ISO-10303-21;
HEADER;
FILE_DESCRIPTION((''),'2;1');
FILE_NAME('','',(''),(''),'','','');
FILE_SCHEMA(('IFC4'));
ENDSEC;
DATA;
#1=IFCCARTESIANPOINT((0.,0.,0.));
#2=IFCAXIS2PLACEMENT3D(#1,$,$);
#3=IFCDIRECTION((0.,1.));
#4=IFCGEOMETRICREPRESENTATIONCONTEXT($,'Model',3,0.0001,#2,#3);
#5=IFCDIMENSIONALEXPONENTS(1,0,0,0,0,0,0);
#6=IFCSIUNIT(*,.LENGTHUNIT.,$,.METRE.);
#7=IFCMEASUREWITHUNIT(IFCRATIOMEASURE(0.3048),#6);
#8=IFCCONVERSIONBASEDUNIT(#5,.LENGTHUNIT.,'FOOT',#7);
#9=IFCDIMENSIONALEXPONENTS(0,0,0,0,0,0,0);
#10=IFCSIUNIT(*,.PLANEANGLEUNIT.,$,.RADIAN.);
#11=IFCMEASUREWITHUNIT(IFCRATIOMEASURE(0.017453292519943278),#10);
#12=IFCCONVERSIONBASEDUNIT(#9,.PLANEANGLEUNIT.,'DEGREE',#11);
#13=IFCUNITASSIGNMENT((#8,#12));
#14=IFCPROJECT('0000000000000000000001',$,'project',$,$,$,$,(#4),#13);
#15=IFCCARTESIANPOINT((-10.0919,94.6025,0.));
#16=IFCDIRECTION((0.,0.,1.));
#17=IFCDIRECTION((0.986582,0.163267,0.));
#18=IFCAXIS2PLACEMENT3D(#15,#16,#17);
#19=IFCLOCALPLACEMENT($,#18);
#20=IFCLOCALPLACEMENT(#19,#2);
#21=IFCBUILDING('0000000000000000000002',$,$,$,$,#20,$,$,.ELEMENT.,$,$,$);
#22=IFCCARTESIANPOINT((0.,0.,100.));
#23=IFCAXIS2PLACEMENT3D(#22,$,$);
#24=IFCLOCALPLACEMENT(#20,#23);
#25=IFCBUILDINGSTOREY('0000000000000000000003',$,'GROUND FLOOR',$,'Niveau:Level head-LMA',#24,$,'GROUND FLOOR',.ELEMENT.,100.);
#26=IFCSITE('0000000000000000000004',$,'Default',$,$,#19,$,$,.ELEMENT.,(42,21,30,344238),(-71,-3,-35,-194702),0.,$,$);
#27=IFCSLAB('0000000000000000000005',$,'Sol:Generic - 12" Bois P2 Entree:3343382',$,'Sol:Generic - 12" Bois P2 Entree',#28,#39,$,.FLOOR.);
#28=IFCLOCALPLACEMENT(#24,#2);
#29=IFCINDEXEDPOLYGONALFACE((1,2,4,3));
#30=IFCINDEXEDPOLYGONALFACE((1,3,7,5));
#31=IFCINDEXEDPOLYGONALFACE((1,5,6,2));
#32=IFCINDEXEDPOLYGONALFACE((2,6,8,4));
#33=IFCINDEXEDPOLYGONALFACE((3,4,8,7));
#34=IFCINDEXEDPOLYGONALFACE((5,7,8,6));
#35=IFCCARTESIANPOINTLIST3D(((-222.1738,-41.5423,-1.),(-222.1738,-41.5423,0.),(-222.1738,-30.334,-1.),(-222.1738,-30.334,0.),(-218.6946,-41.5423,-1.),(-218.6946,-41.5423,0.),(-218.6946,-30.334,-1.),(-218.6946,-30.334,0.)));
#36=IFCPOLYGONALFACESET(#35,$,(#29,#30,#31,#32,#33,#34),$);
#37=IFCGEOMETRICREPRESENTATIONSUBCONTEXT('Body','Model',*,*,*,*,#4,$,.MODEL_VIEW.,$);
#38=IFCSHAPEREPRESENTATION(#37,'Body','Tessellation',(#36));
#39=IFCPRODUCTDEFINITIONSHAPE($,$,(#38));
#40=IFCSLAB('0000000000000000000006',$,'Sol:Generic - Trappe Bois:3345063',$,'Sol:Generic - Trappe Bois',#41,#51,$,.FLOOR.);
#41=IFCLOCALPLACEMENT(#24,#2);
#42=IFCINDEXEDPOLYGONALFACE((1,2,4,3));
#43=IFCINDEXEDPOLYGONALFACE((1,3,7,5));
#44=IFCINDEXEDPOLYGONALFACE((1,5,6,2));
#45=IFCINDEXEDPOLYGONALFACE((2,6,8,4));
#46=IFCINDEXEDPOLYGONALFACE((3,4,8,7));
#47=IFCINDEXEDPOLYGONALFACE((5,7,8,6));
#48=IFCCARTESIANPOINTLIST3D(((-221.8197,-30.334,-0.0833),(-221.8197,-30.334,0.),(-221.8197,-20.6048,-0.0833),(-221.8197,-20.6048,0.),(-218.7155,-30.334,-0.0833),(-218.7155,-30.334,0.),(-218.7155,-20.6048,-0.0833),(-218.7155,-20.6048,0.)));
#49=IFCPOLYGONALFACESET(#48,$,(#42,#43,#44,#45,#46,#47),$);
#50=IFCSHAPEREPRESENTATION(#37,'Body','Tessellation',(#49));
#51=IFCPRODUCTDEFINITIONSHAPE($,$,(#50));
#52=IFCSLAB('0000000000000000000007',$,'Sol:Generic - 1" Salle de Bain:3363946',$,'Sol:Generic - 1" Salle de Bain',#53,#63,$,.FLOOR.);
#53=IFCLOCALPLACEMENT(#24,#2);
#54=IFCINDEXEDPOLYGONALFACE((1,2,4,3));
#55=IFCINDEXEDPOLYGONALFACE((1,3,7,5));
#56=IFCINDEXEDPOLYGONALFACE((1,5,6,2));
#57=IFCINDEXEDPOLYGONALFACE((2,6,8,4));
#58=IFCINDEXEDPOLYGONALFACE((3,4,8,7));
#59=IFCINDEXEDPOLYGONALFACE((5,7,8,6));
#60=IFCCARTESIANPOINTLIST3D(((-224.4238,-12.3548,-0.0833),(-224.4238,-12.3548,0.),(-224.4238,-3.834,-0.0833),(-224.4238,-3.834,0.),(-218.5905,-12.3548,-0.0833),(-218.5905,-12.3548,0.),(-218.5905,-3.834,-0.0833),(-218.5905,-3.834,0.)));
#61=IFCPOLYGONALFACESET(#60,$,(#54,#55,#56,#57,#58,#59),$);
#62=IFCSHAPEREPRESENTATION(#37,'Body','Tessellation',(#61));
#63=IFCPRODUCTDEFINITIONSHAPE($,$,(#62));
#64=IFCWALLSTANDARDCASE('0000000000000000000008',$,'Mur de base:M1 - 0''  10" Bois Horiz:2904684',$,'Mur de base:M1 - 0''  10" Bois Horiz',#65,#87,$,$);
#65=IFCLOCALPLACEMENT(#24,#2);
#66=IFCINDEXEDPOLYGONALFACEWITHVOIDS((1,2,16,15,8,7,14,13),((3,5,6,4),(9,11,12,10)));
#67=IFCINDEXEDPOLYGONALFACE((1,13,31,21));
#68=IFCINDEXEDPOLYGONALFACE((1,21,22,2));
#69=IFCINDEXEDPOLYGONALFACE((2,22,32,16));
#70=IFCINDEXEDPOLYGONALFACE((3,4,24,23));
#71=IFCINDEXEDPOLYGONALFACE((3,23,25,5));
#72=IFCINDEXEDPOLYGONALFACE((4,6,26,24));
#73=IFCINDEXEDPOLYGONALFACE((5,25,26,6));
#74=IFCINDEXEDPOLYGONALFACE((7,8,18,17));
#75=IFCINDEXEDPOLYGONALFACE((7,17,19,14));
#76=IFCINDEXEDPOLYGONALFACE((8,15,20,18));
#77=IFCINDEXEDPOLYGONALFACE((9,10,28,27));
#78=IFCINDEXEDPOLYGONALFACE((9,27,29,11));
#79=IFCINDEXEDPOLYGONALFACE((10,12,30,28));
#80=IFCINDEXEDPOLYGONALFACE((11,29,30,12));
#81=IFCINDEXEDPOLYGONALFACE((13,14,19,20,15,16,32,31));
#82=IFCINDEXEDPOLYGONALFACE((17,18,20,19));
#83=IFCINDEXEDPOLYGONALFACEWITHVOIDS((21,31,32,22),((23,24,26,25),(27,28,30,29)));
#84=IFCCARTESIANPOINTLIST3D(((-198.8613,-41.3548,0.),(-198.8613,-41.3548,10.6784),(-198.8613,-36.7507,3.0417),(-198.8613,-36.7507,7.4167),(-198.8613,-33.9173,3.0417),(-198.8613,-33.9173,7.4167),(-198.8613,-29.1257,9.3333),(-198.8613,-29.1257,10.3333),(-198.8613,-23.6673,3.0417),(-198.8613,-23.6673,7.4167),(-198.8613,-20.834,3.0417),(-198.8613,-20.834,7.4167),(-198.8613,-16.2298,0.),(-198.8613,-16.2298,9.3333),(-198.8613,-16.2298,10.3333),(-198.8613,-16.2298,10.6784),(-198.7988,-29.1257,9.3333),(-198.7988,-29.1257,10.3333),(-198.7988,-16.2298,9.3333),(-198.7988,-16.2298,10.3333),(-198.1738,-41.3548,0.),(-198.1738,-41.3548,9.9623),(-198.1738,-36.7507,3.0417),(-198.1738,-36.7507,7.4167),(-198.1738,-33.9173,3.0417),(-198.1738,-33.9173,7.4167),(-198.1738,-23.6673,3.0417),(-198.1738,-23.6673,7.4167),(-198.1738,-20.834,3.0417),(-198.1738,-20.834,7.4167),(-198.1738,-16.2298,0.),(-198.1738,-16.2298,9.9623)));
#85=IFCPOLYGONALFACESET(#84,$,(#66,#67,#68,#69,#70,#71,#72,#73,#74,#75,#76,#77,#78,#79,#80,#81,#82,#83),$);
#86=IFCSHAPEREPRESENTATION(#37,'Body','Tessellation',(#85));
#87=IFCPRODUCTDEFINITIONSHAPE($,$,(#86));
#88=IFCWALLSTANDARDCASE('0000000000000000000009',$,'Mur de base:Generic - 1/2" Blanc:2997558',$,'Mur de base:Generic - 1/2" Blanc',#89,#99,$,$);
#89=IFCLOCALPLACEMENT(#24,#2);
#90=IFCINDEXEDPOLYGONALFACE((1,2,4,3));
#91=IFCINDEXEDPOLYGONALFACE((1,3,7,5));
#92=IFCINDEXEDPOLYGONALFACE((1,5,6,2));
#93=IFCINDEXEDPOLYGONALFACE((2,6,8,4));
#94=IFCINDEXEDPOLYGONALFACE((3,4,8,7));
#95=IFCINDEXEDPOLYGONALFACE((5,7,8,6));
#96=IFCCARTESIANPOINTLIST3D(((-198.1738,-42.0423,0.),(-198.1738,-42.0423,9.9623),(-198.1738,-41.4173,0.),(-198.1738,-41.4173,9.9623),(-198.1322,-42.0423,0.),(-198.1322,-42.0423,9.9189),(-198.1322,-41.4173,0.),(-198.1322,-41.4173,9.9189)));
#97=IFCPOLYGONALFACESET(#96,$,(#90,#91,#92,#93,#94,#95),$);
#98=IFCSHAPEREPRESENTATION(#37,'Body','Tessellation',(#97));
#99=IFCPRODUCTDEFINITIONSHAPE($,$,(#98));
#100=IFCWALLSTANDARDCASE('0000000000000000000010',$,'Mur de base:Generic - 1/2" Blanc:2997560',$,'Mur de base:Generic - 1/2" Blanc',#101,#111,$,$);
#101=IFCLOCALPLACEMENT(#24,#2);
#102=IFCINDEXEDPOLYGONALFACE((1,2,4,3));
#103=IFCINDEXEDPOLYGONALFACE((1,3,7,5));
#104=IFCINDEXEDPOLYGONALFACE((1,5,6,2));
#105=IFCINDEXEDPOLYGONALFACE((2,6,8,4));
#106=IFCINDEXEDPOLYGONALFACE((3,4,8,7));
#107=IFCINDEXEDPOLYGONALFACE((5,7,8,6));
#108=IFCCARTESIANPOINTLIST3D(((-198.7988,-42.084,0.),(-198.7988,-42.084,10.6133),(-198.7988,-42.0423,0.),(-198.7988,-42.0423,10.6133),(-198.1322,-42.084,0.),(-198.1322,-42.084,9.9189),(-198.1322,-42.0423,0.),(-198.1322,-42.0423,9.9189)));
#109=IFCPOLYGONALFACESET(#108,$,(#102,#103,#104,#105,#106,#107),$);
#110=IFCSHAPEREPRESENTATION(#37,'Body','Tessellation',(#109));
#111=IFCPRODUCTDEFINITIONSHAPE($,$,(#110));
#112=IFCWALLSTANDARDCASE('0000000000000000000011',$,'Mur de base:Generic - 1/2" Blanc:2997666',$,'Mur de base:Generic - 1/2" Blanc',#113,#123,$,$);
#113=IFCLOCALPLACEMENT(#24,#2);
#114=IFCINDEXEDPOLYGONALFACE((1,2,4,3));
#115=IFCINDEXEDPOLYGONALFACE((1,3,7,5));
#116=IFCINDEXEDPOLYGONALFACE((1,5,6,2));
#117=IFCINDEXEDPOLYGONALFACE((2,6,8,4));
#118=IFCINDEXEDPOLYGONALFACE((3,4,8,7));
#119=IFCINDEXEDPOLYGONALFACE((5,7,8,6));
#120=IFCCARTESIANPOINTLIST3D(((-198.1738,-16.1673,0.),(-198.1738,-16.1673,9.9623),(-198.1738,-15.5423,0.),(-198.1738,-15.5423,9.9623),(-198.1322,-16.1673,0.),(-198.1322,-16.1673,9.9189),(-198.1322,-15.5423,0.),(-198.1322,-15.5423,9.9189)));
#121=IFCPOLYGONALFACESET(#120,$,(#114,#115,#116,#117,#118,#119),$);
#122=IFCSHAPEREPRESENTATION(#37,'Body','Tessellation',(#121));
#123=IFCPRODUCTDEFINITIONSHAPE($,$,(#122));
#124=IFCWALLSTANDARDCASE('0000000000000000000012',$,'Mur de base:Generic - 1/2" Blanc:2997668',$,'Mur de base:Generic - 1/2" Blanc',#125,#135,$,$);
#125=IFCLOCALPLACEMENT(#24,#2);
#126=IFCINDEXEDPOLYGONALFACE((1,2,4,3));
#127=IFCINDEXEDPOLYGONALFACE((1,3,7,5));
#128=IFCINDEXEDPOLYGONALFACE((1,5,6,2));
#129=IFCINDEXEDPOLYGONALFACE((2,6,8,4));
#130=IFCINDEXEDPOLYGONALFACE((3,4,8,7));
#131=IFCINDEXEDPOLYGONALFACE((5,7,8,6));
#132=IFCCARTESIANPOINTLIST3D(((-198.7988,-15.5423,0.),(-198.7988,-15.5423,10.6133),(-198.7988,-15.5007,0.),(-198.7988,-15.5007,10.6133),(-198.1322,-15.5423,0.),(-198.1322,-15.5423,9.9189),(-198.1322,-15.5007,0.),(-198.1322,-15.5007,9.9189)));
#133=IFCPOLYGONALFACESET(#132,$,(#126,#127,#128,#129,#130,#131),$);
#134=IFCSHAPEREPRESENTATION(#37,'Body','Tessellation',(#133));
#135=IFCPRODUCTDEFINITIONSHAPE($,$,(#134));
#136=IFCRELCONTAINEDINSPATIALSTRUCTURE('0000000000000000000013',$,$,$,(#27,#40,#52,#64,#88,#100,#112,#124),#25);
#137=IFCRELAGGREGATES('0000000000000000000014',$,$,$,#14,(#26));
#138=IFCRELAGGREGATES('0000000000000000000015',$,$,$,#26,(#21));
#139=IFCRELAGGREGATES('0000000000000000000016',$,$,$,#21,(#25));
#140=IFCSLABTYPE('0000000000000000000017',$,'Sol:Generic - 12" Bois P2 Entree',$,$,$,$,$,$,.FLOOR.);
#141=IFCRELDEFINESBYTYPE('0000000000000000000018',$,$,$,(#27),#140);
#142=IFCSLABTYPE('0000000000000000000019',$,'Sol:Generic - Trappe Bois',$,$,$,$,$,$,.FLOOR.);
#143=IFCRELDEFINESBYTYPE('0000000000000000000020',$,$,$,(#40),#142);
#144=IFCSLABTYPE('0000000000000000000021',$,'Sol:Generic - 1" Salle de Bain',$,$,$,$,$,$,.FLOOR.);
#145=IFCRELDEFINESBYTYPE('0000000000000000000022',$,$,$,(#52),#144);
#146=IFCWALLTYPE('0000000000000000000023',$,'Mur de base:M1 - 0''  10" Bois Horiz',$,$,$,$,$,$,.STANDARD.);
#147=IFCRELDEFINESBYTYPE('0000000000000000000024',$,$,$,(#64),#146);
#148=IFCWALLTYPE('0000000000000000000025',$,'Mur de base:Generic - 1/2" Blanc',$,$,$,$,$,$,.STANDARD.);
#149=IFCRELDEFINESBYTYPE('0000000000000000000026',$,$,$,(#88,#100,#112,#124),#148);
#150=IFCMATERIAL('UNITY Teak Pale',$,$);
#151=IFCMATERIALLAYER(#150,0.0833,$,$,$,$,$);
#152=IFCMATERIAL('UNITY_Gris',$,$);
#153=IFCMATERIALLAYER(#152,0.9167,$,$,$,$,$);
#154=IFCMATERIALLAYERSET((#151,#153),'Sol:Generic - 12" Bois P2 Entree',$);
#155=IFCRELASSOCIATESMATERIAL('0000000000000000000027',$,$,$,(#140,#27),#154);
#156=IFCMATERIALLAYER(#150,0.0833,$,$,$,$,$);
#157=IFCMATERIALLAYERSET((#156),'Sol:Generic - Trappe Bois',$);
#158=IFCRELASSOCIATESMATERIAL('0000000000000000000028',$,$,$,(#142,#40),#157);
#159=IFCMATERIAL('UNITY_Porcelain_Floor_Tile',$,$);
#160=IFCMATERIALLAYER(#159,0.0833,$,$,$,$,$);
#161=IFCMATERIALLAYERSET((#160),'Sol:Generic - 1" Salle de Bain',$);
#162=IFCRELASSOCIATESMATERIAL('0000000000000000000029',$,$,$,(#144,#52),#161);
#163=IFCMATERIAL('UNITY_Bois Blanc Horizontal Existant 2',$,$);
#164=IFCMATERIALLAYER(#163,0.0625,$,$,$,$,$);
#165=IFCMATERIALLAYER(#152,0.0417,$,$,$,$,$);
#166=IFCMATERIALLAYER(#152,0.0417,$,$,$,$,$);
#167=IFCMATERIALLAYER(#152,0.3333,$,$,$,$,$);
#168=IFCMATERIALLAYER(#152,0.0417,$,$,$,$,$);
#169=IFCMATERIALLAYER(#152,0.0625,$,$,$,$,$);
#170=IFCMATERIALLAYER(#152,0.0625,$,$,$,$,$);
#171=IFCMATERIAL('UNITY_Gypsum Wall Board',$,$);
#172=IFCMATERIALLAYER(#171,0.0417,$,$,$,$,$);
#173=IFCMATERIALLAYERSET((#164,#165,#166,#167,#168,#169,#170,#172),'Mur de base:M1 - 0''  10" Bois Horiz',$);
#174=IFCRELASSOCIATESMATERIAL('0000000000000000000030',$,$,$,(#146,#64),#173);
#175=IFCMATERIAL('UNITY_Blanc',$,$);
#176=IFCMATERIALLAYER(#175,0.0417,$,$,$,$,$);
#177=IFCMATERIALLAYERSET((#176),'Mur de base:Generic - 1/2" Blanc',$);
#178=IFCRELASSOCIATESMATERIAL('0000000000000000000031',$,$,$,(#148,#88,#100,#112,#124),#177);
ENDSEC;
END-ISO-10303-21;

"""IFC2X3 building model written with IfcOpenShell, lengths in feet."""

from ifc_helpers import new_model, entity, si_unit, converted_unit, direction, frame, frame_2d, origin, place, context, subcontext, project, spatial, polyline, rectangle, extrude, clip, bounded_halfspace, material, layer, layer_set, layer_usage, type_object, element, save


model = new_model("IFC2X3")

# Units and contexts
model_context = context("Model", 3, precision=0.0001, world=origin(), true_north=direction((0.0, 1.0)))
body_context = subcontext(model_context, "Body", "Model", "MODEL_VIEW")
ifc_project = project(units=[converted_unit("LENGTHUNIT", "FOOT", entity("IfcRatioMeasure", 0.3048), si_unit("LENGTHUNIT", "METRE"), dimensions=[1, 0, 0, 0, 0, 0, 0]), converted_unit("PLANEANGLEUNIT", "DEGREE", entity("IfcRatioMeasure", 0.017453292519943278), si_unit("PLANEANGLEUNIT", "RADIAN"), dimensions=[0, 0, 0, 0, 0, 0, 0])], contexts=[model_context])

# Site, building, storey
site_placement = place(None, frame((-10.0919, 94.6025, 0.0), z_axis=(0.0, 0.0, 1.0), x_axis=(0.986582, 0.163267, 0.0)))
site = spatial("IfcSite", under=ifc_project, at=site_placement, Name="Default", CompositionType="ELEMENT", RefLatitude=(42, 21, 30, 344238), RefLongitude=(-71, -3, -35, -194702), RefElevation=0.0)
building_placement = place(site_placement, origin())
building = spatial("IfcBuilding", under=site, at=building_placement, CompositionType="ELEMENT")
storey_placement = place(building_placement, frame((0.0, 0.0, 100.0)))
storey = spatial("IfcBuildingStorey", under=building, at=storey_placement, Name="GROUND FLOOR", ObjectType="Niveau:Level head-LMA", LongName="GROUND FLOOR", CompositionType="ELEMENT", Elevation=100.0)

# Slabs
ifc_material_1 = material(Name="UNITY_Gris")
ifc_material_2 = material(Name="UNITY Teak Pale")
ifc_layer_1 = layer(ifc_material_2, 0.0833)
ifc_layer_2 = layer(ifc_material_1, 0.9167)
ifc_layer_set_1 = layer_set([ifc_layer_1, ifc_layer_2], Name="Sol:Generic - 12\" Bois P2 Entree")
ifc_layer_usage_1 = layer_usage(ifc_layer_set_1, "AXIS3", "POSITIVE", 0.0)
slab_type_1 = type_object("IfcSlabType", Name="Sol:Generic - 12\" Bois P2 Entree", PredefinedType="FLOOR", material=ifc_layer_set_1)
slab_1_placement = place(storey_placement, origin())
element("IfcSlab", 1, at=slab_1_placement, inside=storey, type_object=slab_type_1, material=ifc_layer_usage_1, Name="Sol:Generic - 12\" Bois P2 Entree:3343382", ObjectType="Sol:Generic - 12\" Bois P2 Entree", PredefinedType="FLOOR", context=body_context, shape_type="SweptSolid", body=[
    extrude(rectangle(XDim=11.2083, YDim=3.4792, at=frame_2d((0.0, 0.0), x_axis=(1.0, 0.0))), frame((-220.4342, -35.9382, 0.0), z_axis=(0.0, 0.0, -1.0), x_axis=(0.0, 1.0, 0.0)), (0.0, 0.0, 1.0), 1.0),
])
ifc_layer_3 = layer(ifc_material_2, 0.0833)
ifc_layer_set_2 = layer_set([ifc_layer_3], Name="Sol:Generic - Trappe Bois")
ifc_layer_usage_2 = layer_usage(ifc_layer_set_2, "AXIS3", "POSITIVE", 0.0)
slab_type_2 = type_object("IfcSlabType", Name="Sol:Generic - Trappe Bois", PredefinedType="FLOOR", material=ifc_layer_set_2)
slab_2_placement = place(storey_placement, origin())
element("IfcSlab", 2, at=slab_2_placement, inside=storey, type_object=slab_type_2, material=ifc_layer_usage_2, Name="Sol:Generic - Trappe Bois:3345063", ObjectType="Sol:Generic - Trappe Bois", PredefinedType="FLOOR", context=body_context, shape_type="SweptSolid", body=[
    extrude(rectangle(XDim=9.7292, YDim=3.1042, at=frame_2d((0.0, 0.0), x_axis=(1.0, 0.0))), frame((-220.2676, -25.4694, 0.0), z_axis=(0.0, 0.0, -1.0), x_axis=(0.0, 1.0, 0.0)), (0.0, 0.0, 1.0), 0.0833),
])
ifc_material_3 = material(Name="UNITY_Porcelain_Floor_Tile")
ifc_layer_4 = layer(ifc_material_3, 0.0833)
ifc_layer_set_3 = layer_set([ifc_layer_4], Name="Sol:Generic - 1\" Salle de Bain")
ifc_layer_usage_3 = layer_usage(ifc_layer_set_3, "AXIS3", "POSITIVE", 0.0)
slab_type_3 = type_object("IfcSlabType", Name="Sol:Generic - 1\" Salle de Bain", PredefinedType="FLOOR", material=ifc_layer_set_3)
slab_3_placement = place(storey_placement, origin())
element("IfcSlab", 3, at=slab_3_placement, inside=storey, type_object=slab_type_3, material=ifc_layer_usage_3, Name="Sol:Generic - 1\" Salle de Bain:3363946", ObjectType="Sol:Generic - 1\" Salle de Bain", PredefinedType="FLOOR", context=body_context, shape_type="SweptSolid", body=[
    extrude(rectangle(XDim=8.5208, YDim=5.8333, at=frame_2d((0.0, 0.0), x_axis=(1.0, 0.0))), frame((-221.5072, -8.0944, 0.0), z_axis=(0.0, 0.0, -1.0), x_axis=(0.0, 1.0, 0.0)), (0.0, 0.0, 1.0), 0.0833),
])

# Wall, openings
ifc_material_4 = material(Name="UNITY_Bois Blanc Horizontal Existant 2")
ifc_layer_5 = layer(ifc_material_4, 0.0625)
ifc_layer_6 = layer(ifc_material_1, 0.0417)
ifc_layer_7 = layer(ifc_material_1, 0.0417)
ifc_layer_8 = layer(ifc_material_1, 0.3333)
ifc_layer_9 = layer(ifc_material_1, 0.0417)
ifc_layer_10 = layer(ifc_material_1, 0.0625)
ifc_layer_11 = layer(ifc_material_1, 0.0625)
ifc_material_5 = material(Name="UNITY_Gypsum Wall Board")
ifc_layer_12 = layer(ifc_material_5, 0.0417)
ifc_layer_set_4 = layer_set([ifc_layer_5, ifc_layer_6, ifc_layer_7, ifc_layer_8, ifc_layer_9, ifc_layer_10, ifc_layer_11, ifc_layer_12], Name="Mur de base:M1 - 0'  10\" Bois Horiz")
ifc_layer_usage_4 = layer_usage(ifc_layer_set_4, "AXIS2", "NEGATIVE", 0.3438)
wall_type_1 = type_object("IfcWallType", Name="Mur de base:M1 - 0'  10\" Bois Horiz", PredefinedType="STANDARD", material=ifc_layer_set_4)
wall_1_placement = place(storey_placement, frame((-198.5176, -16.2298, 0.0), z_axis=(0.0, 0.0, 1.0), x_axis=(0.0, -1.0, 0.0)))
wall_1 = element("IfcWallStandardCase", 4, at=wall_1_placement, inside=storey, type_object=wall_type_1, material=ifc_layer_usage_4, Name="Mur de base:M1 - 0'  10\" Bois Horiz:2904684", ObjectType="Mur de base:M1 - 0'  10\" Bois Horiz", context=body_context, shape_type="Clipping", body=[
    clip(extrude(rectangle(XDim=25.125, YDim=0.6875, at=frame_2d((12.5625, 0.0), x_axis=(-1.0, 0.0))), origin(), (0.0, 0.0, 1.0), 10.6784), bounded_halfspace(frame((0.0, -0.3437, 10.6784), z_axis=(0.0, 0.721387, 0.692532), x_axis=(-1.0, 0.0, 0.0)), False, frame((0.0, -0.3437, 10.6784)), polyline([(0.0, 0.0), (25.125, 0.0), (25.125, 0.6875), (0.0, 0.6875), (0.0, 0.0)]))),
])
opening_1_placement = place(storey_placement, frame((-198.5176, -16.2298, 0.0), z_axis=(0.0, 0.0, 1.0), x_axis=(0.0, -1.0, 0.0)))
element("IfcOpeningElement", 5, at=opening_1_placement, cuts=wall_1, ObjectType="Opening", context=body_context, shape_type="SweptSolid", body=[
    extrude(rectangle(XDim=0.0625, YDim=12.8958, at=frame_2d((0.0, 0.0), x_axis=(1.0, 0.0))), frame((6.4479, -0.3125, 9.3333), z_axis=(0.0, 0.0, 1.0), x_axis=(0.0, 1.0, 0.0)), (0.0, 0.0, 1.0), 1.0),
])
opening_2_placement = place(wall_1_placement, frame((-16.2298, 198.5176, 0.0), z_axis=(0.0, 0.0, 1.0), x_axis=(0.0, 1.0, 0.0)))
element("IfcOpeningElement", 6, at=opening_2_placement, cuts=wall_1, ObjectType="Opening", context=body_context, shape_type="SweptSolid", body=[
    extrude(rectangle(XDim=4.375, YDim=2.8333, at=frame_2d((0.0, 0.0), x_axis=(1.0, 0.0))), frame((-203.8613, -22.2507, 5.2292), z_axis=(1.0, 0.0, 0.0), x_axis=(0.0, 0.0, 1.0)), (0.0, 0.0, 1.0), 10.0),
])
opening_3_placement = place(wall_1_placement, frame((-16.2298, 198.5176, 0.0), z_axis=(0.0, 0.0, 1.0), x_axis=(0.0, 1.0, 0.0)))
element("IfcOpeningElement", 7, at=opening_3_placement, cuts=wall_1, ObjectType="Opening", context=body_context, shape_type="SweptSolid", body=[
    extrude(rectangle(XDim=4.375, YDim=2.8333, at=frame_2d((0.0, 0.0), x_axis=(1.0, 0.0))), frame((-203.8613, -35.334, 5.2292), z_axis=(1.0, 0.0, 0.0), x_axis=(0.0, 0.0, 1.0)), (0.0, 0.0, 1.0), 10.0),
])

# Walls
ifc_material_6 = material(Name="UNITY_Blanc")
ifc_layer_13 = layer(ifc_material_6, 0.0417)
ifc_layer_set_5 = layer_set([ifc_layer_13], Name="Mur de base:Generic - 1/2\" Blanc")
ifc_layer_usage_5 = layer_usage(ifc_layer_set_5, "AXIS2", "NEGATIVE", 0.0208)
wall_type_2 = type_object("IfcWallType", Name="Mur de base:Generic - 1/2\" Blanc", PredefinedType="STANDARD", material=ifc_layer_set_5)
wall_2_placement = place(storey_placement, frame((-198.153, -41.4173, 0.0), z_axis=(0.0, 0.0, 1.0), x_axis=(0.0, -1.0, 0.0)))
element("IfcWallStandardCase", 8, at=wall_2_placement, inside=storey, type_object=wall_type_2, material=ifc_layer_usage_5, Name="Mur de base:Generic - 1/2\" Blanc:2997558", ObjectType="Mur de base:Generic - 1/2\" Blanc", context=body_context, shape_type="Clipping", body=[
    clip(extrude(rectangle(XDim=0.625, YDim=0.0417, at=frame_2d((0.3125, 0.0), x_axis=(-1.0, 0.0))), origin(), (0.0, 0.0, 1.0), 9.9623), bounded_halfspace(frame((0.0, -0.0208, 9.9623), z_axis=(0.0, 0.721387, 0.692532), x_axis=(-1.0, 0.0, 0.0)), False, frame((0.0, -0.0208, 9.9623)), polyline([(0.0, 0.0), (0.625, 0.0), (0.625, 0.0417), (0.0, 0.0417), (0.0, 0.0)]))),
])
ifc_layer_usage_6 = layer_usage(ifc_layer_set_5, "AXIS2", "NEGATIVE", 0.0208)
wall_3_placement = place(storey_placement, frame((-198.1322, -42.0632, 0.0), z_axis=(0.0, 0.0, 1.0), x_axis=(-1.0, 0.0, 0.0)))
element("IfcWallStandardCase", 9, at=wall_3_placement, inside=storey, type_object=wall_type_2, material=ifc_layer_usage_6, Name="Mur de base:Generic - 1/2\" Blanc:2997560", ObjectType="Mur de base:Generic - 1/2\" Blanc", context=body_context, shape_type="Clipping", body=[
    clip(extrude(rectangle(XDim=0.6667, YDim=0.0417, at=frame_2d((0.3333, 0.0), x_axis=(-1.0, 0.0))), origin(), (0.0, 0.0, 1.0), 10.6133), bounded_halfspace(frame((0.0, -0.0208, 9.9189), z_axis=(-0.721387, 0.0, 0.692532), x_axis=(0.0, -1.0, 0.0)), False, frame((0.0, -0.0208, 9.9189)), polyline([(0.0, 0.0), (0.0417, 0.0), (0.6667, 0.0), (0.6667, 0.0417), (0.0, 0.0417), (0.0, 0.0)]))),
])
ifc_layer_usage_7 = layer_usage(ifc_layer_set_5, "AXIS2", "POSITIVE", -0.0208)
wall_4_placement = place(storey_placement, frame((-198.153, -16.1673, 0.0), z_axis=(0.0, 0.0, 1.0), x_axis=(0.0, 1.0, 0.0)))
element("IfcWallStandardCase", 10, at=wall_4_placement, inside=storey, type_object=wall_type_2, material=ifc_layer_usage_7, Name="Mur de base:Generic - 1/2\" Blanc:2997666", ObjectType="Mur de base:Generic - 1/2\" Blanc", context=body_context, shape_type="Clipping", body=[
    clip(extrude(rectangle(XDim=0.625, YDim=0.0417, at=frame_2d((0.3125, 0.0), x_axis=(-1.0, 0.0))), origin(), (0.0, 0.0, 1.0), 9.9623), bounded_halfspace(frame((0.0, -0.0208, 9.9189), z_axis=(0.0, -0.721387, 0.692532), x_axis=(1.0, 0.0, 0.0)), False, frame((0.0, -0.0208, 9.9189)), polyline([(0.0, 0.0), (0.625, 0.0), (0.625, 0.0417), (0.0, 0.0417), (0.0, 0.0)]))),
])
ifc_layer_usage_8 = layer_usage(ifc_layer_set_5, "AXIS2", "POSITIVE", -0.0208)
wall_5_placement = place(storey_placement, frame((-198.1322, -15.5215, 0.0), z_axis=(0.0, 0.0, 1.0), x_axis=(-1.0, 0.0, 0.0)))
element("IfcWallStandardCase", 11, at=wall_5_placement, inside=storey, type_object=wall_type_2, material=ifc_layer_usage_8, Name="Mur de base:Generic - 1/2\" Blanc:2997668", ObjectType="Mur de base:Generic - 1/2\" Blanc", context=body_context, shape_type="Clipping", body=[
    clip(extrude(rectangle(XDim=0.6667, YDim=0.0417, at=frame_2d((0.3333, 0.0), x_axis=(-1.0, 0.0))), origin(), (0.0, 0.0, 1.0), 10.6133), bounded_halfspace(frame((0.0, -0.0208, 9.9189), z_axis=(-0.721387, 0.0, 0.692532), x_axis=(0.0, -1.0, 0.0)), False, frame((0.0, -0.0208, 9.9189)), polyline([(0.0, 0.0), (0.6667, 0.0), (0.6667, 0.0417), (0.0417, 0.0417), (0.0, 0.0417), (0.0, 0.0)]))),
])

save(model, "model.ifc")
